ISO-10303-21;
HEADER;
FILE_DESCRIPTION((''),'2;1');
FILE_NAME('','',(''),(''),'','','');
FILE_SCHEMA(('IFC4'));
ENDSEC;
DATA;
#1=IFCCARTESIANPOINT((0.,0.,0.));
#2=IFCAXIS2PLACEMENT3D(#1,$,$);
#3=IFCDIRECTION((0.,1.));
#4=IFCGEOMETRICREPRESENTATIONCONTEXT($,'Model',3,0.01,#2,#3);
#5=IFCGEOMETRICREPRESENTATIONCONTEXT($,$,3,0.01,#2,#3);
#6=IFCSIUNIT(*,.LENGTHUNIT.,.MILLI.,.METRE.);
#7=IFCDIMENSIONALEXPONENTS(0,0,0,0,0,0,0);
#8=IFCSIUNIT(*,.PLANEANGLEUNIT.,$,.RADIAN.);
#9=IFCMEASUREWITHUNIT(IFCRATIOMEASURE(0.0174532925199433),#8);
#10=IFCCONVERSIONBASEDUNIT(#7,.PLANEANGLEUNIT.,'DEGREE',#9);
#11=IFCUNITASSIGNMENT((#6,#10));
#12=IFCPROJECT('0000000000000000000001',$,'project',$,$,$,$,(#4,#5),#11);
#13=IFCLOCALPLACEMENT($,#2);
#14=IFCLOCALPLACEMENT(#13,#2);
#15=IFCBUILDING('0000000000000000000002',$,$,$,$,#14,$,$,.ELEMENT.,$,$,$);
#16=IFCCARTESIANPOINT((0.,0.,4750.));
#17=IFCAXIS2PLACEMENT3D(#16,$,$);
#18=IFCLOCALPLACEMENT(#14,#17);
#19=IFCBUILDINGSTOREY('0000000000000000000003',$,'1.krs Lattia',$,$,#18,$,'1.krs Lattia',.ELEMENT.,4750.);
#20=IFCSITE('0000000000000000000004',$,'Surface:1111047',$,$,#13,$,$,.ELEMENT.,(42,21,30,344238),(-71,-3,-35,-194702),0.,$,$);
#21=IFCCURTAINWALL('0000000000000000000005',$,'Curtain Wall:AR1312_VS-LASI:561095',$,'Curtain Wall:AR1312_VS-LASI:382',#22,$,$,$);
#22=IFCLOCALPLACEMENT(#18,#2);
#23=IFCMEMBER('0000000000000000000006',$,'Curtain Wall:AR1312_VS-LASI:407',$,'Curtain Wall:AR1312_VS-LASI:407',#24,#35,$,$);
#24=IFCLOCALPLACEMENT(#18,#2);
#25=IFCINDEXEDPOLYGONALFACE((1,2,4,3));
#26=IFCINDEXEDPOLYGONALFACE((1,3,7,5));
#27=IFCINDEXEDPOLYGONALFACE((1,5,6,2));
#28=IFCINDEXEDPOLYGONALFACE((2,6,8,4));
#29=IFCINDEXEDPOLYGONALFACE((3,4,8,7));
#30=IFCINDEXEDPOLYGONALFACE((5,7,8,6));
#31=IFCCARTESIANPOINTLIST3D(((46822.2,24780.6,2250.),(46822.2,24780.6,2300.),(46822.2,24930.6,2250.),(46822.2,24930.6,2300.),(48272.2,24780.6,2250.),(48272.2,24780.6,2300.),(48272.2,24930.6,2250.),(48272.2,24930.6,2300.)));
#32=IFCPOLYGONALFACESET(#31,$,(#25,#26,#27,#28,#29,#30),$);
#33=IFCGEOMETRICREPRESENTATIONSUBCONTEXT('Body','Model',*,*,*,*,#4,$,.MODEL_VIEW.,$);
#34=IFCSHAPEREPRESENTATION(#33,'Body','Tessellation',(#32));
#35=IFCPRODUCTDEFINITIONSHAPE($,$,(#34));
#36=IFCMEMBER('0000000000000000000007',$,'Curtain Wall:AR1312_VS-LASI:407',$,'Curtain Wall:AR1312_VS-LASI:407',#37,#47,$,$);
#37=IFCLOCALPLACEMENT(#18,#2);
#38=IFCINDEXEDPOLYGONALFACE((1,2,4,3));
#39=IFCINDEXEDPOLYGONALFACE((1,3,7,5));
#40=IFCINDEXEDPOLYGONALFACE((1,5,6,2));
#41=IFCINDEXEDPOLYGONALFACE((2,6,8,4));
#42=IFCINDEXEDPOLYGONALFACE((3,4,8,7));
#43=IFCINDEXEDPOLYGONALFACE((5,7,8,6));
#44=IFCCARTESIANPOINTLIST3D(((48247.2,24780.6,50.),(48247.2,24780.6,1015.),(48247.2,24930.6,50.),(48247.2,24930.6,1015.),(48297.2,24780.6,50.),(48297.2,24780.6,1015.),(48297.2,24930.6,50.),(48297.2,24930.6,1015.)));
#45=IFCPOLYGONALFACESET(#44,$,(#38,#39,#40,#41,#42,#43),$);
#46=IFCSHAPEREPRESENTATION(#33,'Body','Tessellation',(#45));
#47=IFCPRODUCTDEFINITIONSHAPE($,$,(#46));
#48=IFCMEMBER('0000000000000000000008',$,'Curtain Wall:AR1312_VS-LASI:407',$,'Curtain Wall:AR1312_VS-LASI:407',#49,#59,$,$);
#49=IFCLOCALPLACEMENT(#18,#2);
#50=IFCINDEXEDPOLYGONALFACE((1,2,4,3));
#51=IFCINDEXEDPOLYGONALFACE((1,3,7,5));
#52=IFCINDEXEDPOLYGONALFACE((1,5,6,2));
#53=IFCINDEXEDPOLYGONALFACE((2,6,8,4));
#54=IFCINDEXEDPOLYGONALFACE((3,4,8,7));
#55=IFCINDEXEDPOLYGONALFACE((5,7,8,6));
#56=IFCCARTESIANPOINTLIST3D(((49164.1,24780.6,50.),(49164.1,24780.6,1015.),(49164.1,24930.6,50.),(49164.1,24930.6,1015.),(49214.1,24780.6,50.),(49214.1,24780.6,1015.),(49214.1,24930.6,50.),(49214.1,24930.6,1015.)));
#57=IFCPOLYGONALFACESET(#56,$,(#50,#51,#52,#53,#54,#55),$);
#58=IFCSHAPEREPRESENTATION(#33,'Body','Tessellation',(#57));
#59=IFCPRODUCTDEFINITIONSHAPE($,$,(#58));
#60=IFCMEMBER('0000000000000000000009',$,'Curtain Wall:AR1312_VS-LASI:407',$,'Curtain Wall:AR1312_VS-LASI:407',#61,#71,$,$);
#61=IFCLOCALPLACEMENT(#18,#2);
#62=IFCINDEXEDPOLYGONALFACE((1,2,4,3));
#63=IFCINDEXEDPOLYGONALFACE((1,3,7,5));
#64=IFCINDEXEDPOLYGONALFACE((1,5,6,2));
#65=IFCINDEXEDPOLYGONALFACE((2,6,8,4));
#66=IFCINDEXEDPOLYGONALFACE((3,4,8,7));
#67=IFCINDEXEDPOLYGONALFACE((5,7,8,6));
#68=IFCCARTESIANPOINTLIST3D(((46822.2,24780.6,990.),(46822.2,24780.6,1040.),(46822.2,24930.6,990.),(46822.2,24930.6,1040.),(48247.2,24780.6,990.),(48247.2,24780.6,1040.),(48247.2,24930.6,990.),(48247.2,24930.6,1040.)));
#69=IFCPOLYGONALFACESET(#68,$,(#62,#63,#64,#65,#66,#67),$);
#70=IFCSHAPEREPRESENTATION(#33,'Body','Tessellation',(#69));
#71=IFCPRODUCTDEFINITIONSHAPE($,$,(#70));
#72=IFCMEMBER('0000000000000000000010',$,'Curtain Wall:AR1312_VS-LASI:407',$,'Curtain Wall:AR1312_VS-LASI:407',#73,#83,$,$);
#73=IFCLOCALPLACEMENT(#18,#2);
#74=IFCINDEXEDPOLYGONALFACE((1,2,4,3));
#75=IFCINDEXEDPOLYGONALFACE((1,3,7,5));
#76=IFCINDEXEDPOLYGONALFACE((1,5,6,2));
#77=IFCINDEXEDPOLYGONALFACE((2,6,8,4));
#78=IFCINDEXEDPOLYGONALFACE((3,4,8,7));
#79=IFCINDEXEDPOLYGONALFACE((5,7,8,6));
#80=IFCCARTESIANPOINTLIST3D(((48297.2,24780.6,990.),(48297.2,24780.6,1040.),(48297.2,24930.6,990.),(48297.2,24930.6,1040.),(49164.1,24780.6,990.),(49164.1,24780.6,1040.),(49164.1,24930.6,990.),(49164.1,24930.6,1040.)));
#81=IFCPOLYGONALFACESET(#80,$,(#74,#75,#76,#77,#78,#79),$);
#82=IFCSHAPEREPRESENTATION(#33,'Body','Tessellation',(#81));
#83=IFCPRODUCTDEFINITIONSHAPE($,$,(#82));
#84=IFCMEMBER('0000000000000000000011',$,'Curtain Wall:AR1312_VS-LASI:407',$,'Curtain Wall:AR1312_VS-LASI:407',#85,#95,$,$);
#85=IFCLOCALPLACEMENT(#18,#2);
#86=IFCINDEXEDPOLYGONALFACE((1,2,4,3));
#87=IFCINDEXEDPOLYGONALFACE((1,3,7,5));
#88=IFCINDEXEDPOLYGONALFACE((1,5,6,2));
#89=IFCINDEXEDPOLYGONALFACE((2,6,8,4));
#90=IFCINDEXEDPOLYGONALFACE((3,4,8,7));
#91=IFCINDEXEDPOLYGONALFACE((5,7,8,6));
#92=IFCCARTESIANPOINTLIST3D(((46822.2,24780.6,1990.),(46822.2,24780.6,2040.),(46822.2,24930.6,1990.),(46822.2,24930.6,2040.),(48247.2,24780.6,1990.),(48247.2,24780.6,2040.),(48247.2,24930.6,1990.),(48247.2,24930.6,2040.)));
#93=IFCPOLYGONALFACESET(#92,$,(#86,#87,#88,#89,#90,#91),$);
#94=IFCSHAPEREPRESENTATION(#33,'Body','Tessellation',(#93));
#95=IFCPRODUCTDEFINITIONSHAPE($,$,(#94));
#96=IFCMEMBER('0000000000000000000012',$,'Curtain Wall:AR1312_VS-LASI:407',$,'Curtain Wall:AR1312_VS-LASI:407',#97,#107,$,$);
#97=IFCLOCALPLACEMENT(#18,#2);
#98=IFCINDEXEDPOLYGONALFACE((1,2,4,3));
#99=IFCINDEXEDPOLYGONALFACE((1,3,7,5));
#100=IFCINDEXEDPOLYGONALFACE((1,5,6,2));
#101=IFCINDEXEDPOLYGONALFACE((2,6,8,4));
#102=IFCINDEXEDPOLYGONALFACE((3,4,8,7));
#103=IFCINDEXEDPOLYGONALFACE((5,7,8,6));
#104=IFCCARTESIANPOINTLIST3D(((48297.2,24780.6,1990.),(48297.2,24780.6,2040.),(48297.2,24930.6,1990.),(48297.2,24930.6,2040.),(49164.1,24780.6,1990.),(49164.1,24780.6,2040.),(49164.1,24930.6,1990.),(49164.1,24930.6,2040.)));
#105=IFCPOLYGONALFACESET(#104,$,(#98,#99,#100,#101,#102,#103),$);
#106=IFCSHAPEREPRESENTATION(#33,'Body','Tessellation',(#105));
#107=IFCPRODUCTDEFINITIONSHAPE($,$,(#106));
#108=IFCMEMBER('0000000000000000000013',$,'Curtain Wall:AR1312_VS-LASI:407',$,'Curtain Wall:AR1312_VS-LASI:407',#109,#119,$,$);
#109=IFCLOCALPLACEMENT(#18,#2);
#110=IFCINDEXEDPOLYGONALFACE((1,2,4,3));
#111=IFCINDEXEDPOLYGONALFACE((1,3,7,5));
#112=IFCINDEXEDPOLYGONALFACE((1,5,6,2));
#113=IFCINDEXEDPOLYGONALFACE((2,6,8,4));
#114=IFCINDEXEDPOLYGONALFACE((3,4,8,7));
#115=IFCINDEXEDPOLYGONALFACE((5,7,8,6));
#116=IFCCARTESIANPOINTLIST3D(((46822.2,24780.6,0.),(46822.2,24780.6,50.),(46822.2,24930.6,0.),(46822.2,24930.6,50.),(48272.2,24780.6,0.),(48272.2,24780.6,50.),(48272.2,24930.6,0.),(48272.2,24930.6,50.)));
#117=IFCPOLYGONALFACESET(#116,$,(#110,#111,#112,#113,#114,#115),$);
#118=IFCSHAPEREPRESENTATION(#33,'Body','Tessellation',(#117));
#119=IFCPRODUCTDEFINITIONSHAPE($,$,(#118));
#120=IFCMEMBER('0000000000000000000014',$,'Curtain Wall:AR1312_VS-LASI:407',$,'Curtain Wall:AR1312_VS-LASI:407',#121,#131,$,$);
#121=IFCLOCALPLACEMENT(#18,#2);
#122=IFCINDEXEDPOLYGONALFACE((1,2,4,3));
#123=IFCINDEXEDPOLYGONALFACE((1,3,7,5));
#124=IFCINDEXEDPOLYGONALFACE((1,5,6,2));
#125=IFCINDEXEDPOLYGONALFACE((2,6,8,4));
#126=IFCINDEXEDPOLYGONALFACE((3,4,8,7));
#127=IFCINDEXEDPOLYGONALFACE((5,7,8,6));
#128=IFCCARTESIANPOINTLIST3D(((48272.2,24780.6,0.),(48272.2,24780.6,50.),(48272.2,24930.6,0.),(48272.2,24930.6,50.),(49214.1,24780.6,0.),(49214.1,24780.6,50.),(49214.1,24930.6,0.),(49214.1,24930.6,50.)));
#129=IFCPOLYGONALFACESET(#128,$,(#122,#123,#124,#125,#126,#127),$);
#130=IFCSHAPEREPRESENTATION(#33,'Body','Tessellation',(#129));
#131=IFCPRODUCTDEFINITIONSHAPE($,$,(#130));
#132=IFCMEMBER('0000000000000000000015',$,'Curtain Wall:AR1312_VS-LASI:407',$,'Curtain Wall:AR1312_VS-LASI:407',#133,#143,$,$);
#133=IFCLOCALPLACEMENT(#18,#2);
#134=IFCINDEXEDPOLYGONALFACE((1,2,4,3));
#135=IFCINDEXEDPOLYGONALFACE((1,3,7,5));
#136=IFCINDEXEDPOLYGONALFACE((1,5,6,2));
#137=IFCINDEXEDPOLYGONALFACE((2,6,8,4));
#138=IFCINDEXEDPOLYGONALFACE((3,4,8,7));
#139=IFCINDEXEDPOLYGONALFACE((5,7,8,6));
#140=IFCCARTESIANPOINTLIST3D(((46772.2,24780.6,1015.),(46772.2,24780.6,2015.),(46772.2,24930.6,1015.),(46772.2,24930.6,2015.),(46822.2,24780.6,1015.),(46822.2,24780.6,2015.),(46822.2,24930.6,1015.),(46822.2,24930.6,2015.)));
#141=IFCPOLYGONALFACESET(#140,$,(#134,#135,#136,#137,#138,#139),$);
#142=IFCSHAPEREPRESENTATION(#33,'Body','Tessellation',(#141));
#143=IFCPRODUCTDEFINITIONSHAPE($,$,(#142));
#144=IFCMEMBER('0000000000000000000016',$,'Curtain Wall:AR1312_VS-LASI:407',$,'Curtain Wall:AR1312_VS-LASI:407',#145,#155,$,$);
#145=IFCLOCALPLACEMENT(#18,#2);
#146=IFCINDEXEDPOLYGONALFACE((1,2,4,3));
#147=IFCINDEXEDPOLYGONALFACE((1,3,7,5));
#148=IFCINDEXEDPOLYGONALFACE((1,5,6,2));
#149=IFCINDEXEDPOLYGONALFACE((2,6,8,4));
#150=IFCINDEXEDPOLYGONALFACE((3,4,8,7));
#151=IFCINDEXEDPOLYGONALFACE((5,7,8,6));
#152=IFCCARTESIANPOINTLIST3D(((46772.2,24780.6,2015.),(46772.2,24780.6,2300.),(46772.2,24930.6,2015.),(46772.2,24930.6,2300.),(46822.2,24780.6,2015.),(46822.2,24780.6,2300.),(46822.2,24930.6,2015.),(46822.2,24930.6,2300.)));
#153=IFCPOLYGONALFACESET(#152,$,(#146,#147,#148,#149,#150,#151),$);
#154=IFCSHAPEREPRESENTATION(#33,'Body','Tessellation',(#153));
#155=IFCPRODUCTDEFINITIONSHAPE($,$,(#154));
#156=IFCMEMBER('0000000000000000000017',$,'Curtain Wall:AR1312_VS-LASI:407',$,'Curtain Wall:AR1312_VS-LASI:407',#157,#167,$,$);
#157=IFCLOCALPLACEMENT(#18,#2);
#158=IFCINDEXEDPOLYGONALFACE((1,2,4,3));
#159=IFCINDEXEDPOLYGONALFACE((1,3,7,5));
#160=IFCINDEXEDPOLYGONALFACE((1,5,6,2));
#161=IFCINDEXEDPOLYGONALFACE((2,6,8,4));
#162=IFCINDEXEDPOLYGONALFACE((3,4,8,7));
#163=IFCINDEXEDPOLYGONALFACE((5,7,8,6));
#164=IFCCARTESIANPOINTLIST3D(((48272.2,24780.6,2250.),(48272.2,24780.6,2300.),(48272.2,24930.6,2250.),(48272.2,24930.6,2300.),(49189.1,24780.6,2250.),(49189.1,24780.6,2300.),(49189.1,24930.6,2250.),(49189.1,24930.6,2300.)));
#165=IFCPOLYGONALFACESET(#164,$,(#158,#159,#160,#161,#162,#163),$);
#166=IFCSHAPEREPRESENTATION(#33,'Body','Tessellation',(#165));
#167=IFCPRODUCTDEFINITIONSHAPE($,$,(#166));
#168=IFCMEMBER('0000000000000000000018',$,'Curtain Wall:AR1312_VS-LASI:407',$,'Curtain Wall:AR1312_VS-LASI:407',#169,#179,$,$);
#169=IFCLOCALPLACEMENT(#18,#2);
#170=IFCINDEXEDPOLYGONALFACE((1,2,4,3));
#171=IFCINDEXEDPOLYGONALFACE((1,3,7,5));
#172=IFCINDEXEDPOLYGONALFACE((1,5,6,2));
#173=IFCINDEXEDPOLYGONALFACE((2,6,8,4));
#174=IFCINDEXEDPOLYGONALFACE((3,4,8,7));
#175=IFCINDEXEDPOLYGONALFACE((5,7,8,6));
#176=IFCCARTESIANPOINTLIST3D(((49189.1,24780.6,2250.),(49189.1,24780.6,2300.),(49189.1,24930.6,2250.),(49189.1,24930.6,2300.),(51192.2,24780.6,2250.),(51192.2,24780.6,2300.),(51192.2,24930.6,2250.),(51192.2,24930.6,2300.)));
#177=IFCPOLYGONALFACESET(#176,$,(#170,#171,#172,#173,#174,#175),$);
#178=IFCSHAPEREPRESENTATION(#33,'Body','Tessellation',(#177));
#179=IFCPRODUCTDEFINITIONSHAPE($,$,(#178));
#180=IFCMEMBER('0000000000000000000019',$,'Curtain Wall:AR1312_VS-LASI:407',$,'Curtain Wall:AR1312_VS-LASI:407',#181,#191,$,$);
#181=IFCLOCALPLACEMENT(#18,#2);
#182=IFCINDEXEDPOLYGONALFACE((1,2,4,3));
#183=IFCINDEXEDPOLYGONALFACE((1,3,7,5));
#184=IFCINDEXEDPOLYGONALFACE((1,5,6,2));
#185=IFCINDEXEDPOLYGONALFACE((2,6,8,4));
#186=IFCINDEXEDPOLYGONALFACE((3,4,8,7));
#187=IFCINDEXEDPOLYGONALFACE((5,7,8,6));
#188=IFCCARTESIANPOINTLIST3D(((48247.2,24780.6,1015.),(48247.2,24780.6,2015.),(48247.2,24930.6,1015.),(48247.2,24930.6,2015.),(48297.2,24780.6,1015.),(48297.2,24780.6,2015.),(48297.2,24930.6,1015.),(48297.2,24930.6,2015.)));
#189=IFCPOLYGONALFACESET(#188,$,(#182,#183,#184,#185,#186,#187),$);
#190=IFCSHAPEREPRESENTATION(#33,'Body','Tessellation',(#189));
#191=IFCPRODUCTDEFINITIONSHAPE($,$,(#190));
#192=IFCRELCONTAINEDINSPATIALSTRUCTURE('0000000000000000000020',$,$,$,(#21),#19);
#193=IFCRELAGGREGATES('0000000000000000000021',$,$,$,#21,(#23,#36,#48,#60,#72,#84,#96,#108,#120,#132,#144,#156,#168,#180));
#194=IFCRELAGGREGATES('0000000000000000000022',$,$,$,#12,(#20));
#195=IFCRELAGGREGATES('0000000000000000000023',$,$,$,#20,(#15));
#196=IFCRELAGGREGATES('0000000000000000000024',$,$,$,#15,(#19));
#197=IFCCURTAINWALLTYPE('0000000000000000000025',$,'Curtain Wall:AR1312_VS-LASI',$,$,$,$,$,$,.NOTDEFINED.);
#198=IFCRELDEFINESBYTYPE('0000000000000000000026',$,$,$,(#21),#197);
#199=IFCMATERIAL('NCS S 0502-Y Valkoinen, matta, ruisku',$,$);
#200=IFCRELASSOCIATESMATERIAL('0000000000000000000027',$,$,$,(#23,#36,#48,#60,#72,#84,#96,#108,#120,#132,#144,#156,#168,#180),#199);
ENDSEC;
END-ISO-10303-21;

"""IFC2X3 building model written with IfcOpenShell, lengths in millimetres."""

from ifc_helpers import new_model, entity, si_unit, converted_unit, direction, frame, frame_2d, origin, place, context, subcontext, project, spatial, rectangle, extrude, material, type_object, element, aggregate, save


model = new_model("IFC2X3")

# Units and contexts
model_context = context("Model", 3, precision=0.01, world=origin(), true_north=direction((0.0, 1.0)))
context_of_model = context(None, 3, precision=0.01, world=origin(), true_north=direction((0.0, 1.0)))
body_context = subcontext(model_context, "Body", "Model", "MODEL_VIEW")
ifc_project = project(units=[si_unit("LENGTHUNIT", "METRE", prefix="MILLI"), converted_unit("PLANEANGLEUNIT", "DEGREE", entity("IfcRatioMeasure", 0.0174532925199433), si_unit("PLANEANGLEUNIT", "RADIAN"), dimensions=[0, 0, 0, 0, 0, 0, 0])], contexts=[model_context, context_of_model])

# Site, building, storey
site_placement = place(None, origin())
site = spatial("IfcSite", under=ifc_project, at=site_placement, Name="Surface:1111047", CompositionType="ELEMENT", RefLatitude=(42, 21, 30, 344238), RefLongitude=(-71, -3, -35, -194702), RefElevation=0.0)
building_placement = place(site_placement, origin())
building = spatial("IfcBuilding", under=site, at=building_placement, CompositionType="ELEMENT")
storey_placement = place(building_placement, frame((0.0, 0.0, 4750.0)))
storey = spatial("IfcBuildingStorey", under=building, at=storey_placement, Name="1.krs Lattia", LongName="1.krs Lattia", CompositionType="ELEMENT", Elevation=4750.0)

# Curtain wall, members
curtain_wall_type = type_object("IfcCurtainWallType", Name="Curtain Wall:AR1312_VS-LASI", PredefinedType="NOTDEFINED")
curtain_wall_1_placement = place(storey_placement, frame((0.0, 0.0, -4750.0)))
curtain_wall_1 = element("IfcCurtainWall", 1, at=curtain_wall_1_placement, inside=storey, type_object=curtain_wall_type, Name="Curtain Wall:AR1312_VS-LASI:561095", ObjectType="Curtain Wall:AR1312_VS-LASI:382")
ifc_material = material(Name="NCS S 0502-Y Valkoinen, matta, ruisku")
member_1_placement = place(curtain_wall_1_placement, frame((0.0, 0.0, 4750.0)))
member_1 = element("IfcMember", 2, at=member_1_placement, material=ifc_material, Name="Curtain Wall:AR1312_VS-LASI:407", ObjectType="Curtain Wall:AR1312_VS-LASI:407", context=body_context, shape_type="SweptSolid", body=[
    extrude(rectangle(XDim=50.0, YDim=150.0, at=frame_2d((0.0, 0.0), x_axis=(1.0, 0.0))), frame((46822.2, 24855.6, 2275.0), z_axis=(1.0, 0.0, 0.0), x_axis=(0.0, 0.0, -1.0)), (0.0, 0.0, 1.0), 1450.0),
])
member_2_placement = place(curtain_wall_1_placement, frame((0.0, 0.0, 4750.0)))
member_2 = element("IfcMember", 3, at=member_2_placement, material=ifc_material, Name="Curtain Wall:AR1312_VS-LASI:407", ObjectType="Curtain Wall:AR1312_VS-LASI:407", context=body_context, shape_type="SweptSolid", body=[
    extrude(rectangle(XDim=50.0, YDim=150.0, at=frame_2d((0.0, 0.0), x_axis=(1.0, 0.0))), frame((48272.2, 24855.6, 50.0), z_axis=(0.0, 0.0, 1.0), x_axis=(-1.0, 0.0, 0.0)), (0.0, 0.0, 1.0), 965.0),
])
member_3_placement = place(curtain_wall_1_placement, frame((0.0, 0.0, 4750.0)))
member_3 = element("IfcMember", 4, at=member_3_placement, material=ifc_material, Name="Curtain Wall:AR1312_VS-LASI:407", ObjectType="Curtain Wall:AR1312_VS-LASI:407", context=body_context, shape_type="SweptSolid", body=[
    extrude(rectangle(XDim=50.0, YDim=150.0, at=frame_2d((0.0, 0.0), x_axis=(1.0, 0.0))), frame((49189.1, 24855.6, 50.0), z_axis=(0.0, 0.0, 1.0), x_axis=(-1.0, 0.0, 0.0)), (0.0, 0.0, 1.0), 965.0),
])
member_4_placement = place(curtain_wall_1_placement, frame((0.0, 0.0, 4750.0)))
member_4 = element("IfcMember", 5, at=member_4_placement, material=ifc_material, Name="Curtain Wall:AR1312_VS-LASI:407", ObjectType="Curtain Wall:AR1312_VS-LASI:407", context=body_context, shape_type="SweptSolid", body=[
    extrude(rectangle(XDim=50.0, YDim=150.0, at=frame_2d((0.0, 0.0), x_axis=(1.0, 0.0))), frame((46822.2, 24855.6, 1015.0), z_axis=(1.0, 0.0, 0.0), x_axis=(0.0, 0.0, -1.0)), (0.0, 0.0, 1.0), 1425.0),
])
member_5_placement = place(curtain_wall_1_placement, frame((0.0, 0.0, 4750.0)))
member_5 = element("IfcMember", 6, at=member_5_placement, material=ifc_material, Name="Curtain Wall:AR1312_VS-LASI:407", ObjectType="Curtain Wall:AR1312_VS-LASI:407", context=body_context, shape_type="SweptSolid", body=[
    extrude(rectangle(XDim=50.0, YDim=150.0, at=frame_2d((0.0, 0.0), x_axis=(1.0, 0.0))), frame((48297.2, 24855.6, 1015.0), z_axis=(1.0, 0.0, 0.0), x_axis=(0.0, 0.0, -1.0)), (0.0, 0.0, 1.0), 866.9),
])
member_6_placement = place(curtain_wall_1_placement, frame((0.0, 0.0, 4750.0)))
member_6 = element("IfcMember", 7, at=member_6_placement, material=ifc_material, Name="Curtain Wall:AR1312_VS-LASI:407", ObjectType="Curtain Wall:AR1312_VS-LASI:407", context=body_context, shape_type="SweptSolid", body=[
    extrude(rectangle(XDim=50.0, YDim=150.0, at=frame_2d((0.0, 0.0), x_axis=(1.0, 0.0))), frame((46822.2, 24855.6, 2015.0), z_axis=(1.0, 0.0, 0.0), x_axis=(0.0, 0.0, -1.0)), (0.0, 0.0, 1.0), 1425.0),
])
member_7_placement = place(curtain_wall_1_placement, frame((0.0, 0.0, 4750.0)))
member_7 = element("IfcMember", 8, at=member_7_placement, material=ifc_material, Name="Curtain Wall:AR1312_VS-LASI:407", ObjectType="Curtain Wall:AR1312_VS-LASI:407", context=body_context, shape_type="SweptSolid", body=[
    extrude(rectangle(XDim=50.0, YDim=150.0, at=frame_2d((0.0, 0.0), x_axis=(1.0, 0.0))), frame((48297.2, 24855.6, 2015.0), z_axis=(1.0, 0.0, 0.0), x_axis=(0.0, 0.0, -1.0)), (0.0, 0.0, 1.0), 866.9),
])
member_8_placement = place(curtain_wall_1_placement, frame((0.0, 0.0, 4750.0)))
member_8 = element("IfcMember", 9, at=member_8_placement, material=ifc_material, Name="Curtain Wall:AR1312_VS-LASI:407", ObjectType="Curtain Wall:AR1312_VS-LASI:407", context=body_context, shape_type="SweptSolid", body=[
    extrude(rectangle(XDim=50.0, YDim=150.0, at=frame_2d((0.0, 0.0), x_axis=(1.0, 0.0))), frame((48272.2, 24855.6, 25.0), z_axis=(-1.0, 0.0, 0.0), x_axis=(0.0, 0.0, -1.0)), (0.0, 0.0, 1.0), 1450.0),
])
member_9_placement = place(curtain_wall_1_placement, frame((0.0, 0.0, 4750.0)))
member_9 = element("IfcMember", 10, at=member_9_placement, material=ifc_material, Name="Curtain Wall:AR1312_VS-LASI:407", ObjectType="Curtain Wall:AR1312_VS-LASI:407", context=body_context, shape_type="SweptSolid", body=[
    extrude(rectangle(XDim=50.0, YDim=150.0, at=frame_2d((0.0, 0.0), x_axis=(1.0, 0.0))), frame((49214.1, 24855.6, 25.0), z_axis=(-1.0, 0.0, 0.0), x_axis=(0.0, 0.0, -1.0)), (0.0, 0.0, 1.0), 941.9),
])
member_10_placement = place(curtain_wall_1_placement, frame((0.0, 0.0, 4750.0)))
member_10 = element("IfcMember", 11, at=member_10_placement, material=ifc_material, Name="Curtain Wall:AR1312_VS-LASI:407", ObjectType="Curtain Wall:AR1312_VS-LASI:407", context=body_context, shape_type="SweptSolid", body=[
    extrude(rectangle(XDim=50.0, YDim=150.0, at=frame_2d((0.0, 0.0), x_axis=(1.0, 0.0))), frame((46797.2, 24855.6, 1015.0), z_axis=(0.0, 0.0, 1.0), x_axis=(-1.0, 0.0, 0.0)), (0.0, 0.0, 1.0), 1000.0),
])
member_11_placement = place(curtain_wall_1_placement, frame((0.0, 0.0, 4750.0)))
member_11 = element("IfcMember", 12, at=member_11_placement, material=ifc_material, Name="Curtain Wall:AR1312_VS-LASI:407", ObjectType="Curtain Wall:AR1312_VS-LASI:407", context=body_context, shape_type="SweptSolid", body=[
    extrude(rectangle(XDim=50.0, YDim=150.0, at=frame_2d((0.0, 0.0), x_axis=(1.0, 0.0))), frame((46797.2, 24855.6, 2015.0), z_axis=(0.0, 0.0, 1.0), x_axis=(-1.0, 0.0, 0.0)), (0.0, 0.0, 1.0), 285.0),
])
member_12_placement = place(curtain_wall_1_placement, frame((0.0, 0.0, 4750.0)))
member_12 = element("IfcMember", 13, at=member_12_placement, material=ifc_material, Name="Curtain Wall:AR1312_VS-LASI:407", ObjectType="Curtain Wall:AR1312_VS-LASI:407", context=body_context, shape_type="SweptSolid", body=[
    extrude(rectangle(XDim=50.0, YDim=150.0, at=frame_2d((0.0, 0.0), x_axis=(1.0, 0.0))), frame((48272.2, 24855.6, 2275.0), z_axis=(1.0, 0.0, 0.0), x_axis=(0.0, 0.0, -1.0)), (0.0, 0.0, 1.0), 916.9),
])
member_13_placement = place(curtain_wall_1_placement, frame((0.0, 0.0, 4750.0)))
member_13 = element("IfcMember", 14, at=member_13_placement, material=ifc_material, Name="Curtain Wall:AR1312_VS-LASI:407", ObjectType="Curtain Wall:AR1312_VS-LASI:407", context=body_context, shape_type="SweptSolid", body=[
    extrude(rectangle(XDim=50.0, YDim=150.0, at=frame_2d((0.0, 0.0), x_axis=(1.0, 0.0))), frame((49189.1, 24855.6, 2275.0), z_axis=(1.0, 0.0, 0.0), x_axis=(0.0, 0.0, -1.0)), (0.0, 0.0, 1.0), 2003.1),
])
member_14_placement = place(curtain_wall_1_placement, frame((0.0, 0.0, 4750.0)))
member_14 = element("IfcMember", 15, at=member_14_placement, material=ifc_material, Name="Curtain Wall:AR1312_VS-LASI:407", ObjectType="Curtain Wall:AR1312_VS-LASI:407", context=body_context, shape_type="SweptSolid", body=[
    extrude(rectangle(XDim=50.0, YDim=150.0, at=frame_2d((0.0, 0.0), x_axis=(1.0, 0.0))), frame((48272.2, 24855.6, 1015.0), z_axis=(0.0, 0.0, 1.0), x_axis=(-1.0, 0.0, 0.0)), (0.0, 0.0, 1.0), 1000.0),
])
aggregate(curtain_wall_1, [member_1, member_2, member_3, member_4, member_5, member_6, member_7, member_8, member_9, member_10, member_11, member_12, member_13, member_14])

save(model, "model.ifc")
